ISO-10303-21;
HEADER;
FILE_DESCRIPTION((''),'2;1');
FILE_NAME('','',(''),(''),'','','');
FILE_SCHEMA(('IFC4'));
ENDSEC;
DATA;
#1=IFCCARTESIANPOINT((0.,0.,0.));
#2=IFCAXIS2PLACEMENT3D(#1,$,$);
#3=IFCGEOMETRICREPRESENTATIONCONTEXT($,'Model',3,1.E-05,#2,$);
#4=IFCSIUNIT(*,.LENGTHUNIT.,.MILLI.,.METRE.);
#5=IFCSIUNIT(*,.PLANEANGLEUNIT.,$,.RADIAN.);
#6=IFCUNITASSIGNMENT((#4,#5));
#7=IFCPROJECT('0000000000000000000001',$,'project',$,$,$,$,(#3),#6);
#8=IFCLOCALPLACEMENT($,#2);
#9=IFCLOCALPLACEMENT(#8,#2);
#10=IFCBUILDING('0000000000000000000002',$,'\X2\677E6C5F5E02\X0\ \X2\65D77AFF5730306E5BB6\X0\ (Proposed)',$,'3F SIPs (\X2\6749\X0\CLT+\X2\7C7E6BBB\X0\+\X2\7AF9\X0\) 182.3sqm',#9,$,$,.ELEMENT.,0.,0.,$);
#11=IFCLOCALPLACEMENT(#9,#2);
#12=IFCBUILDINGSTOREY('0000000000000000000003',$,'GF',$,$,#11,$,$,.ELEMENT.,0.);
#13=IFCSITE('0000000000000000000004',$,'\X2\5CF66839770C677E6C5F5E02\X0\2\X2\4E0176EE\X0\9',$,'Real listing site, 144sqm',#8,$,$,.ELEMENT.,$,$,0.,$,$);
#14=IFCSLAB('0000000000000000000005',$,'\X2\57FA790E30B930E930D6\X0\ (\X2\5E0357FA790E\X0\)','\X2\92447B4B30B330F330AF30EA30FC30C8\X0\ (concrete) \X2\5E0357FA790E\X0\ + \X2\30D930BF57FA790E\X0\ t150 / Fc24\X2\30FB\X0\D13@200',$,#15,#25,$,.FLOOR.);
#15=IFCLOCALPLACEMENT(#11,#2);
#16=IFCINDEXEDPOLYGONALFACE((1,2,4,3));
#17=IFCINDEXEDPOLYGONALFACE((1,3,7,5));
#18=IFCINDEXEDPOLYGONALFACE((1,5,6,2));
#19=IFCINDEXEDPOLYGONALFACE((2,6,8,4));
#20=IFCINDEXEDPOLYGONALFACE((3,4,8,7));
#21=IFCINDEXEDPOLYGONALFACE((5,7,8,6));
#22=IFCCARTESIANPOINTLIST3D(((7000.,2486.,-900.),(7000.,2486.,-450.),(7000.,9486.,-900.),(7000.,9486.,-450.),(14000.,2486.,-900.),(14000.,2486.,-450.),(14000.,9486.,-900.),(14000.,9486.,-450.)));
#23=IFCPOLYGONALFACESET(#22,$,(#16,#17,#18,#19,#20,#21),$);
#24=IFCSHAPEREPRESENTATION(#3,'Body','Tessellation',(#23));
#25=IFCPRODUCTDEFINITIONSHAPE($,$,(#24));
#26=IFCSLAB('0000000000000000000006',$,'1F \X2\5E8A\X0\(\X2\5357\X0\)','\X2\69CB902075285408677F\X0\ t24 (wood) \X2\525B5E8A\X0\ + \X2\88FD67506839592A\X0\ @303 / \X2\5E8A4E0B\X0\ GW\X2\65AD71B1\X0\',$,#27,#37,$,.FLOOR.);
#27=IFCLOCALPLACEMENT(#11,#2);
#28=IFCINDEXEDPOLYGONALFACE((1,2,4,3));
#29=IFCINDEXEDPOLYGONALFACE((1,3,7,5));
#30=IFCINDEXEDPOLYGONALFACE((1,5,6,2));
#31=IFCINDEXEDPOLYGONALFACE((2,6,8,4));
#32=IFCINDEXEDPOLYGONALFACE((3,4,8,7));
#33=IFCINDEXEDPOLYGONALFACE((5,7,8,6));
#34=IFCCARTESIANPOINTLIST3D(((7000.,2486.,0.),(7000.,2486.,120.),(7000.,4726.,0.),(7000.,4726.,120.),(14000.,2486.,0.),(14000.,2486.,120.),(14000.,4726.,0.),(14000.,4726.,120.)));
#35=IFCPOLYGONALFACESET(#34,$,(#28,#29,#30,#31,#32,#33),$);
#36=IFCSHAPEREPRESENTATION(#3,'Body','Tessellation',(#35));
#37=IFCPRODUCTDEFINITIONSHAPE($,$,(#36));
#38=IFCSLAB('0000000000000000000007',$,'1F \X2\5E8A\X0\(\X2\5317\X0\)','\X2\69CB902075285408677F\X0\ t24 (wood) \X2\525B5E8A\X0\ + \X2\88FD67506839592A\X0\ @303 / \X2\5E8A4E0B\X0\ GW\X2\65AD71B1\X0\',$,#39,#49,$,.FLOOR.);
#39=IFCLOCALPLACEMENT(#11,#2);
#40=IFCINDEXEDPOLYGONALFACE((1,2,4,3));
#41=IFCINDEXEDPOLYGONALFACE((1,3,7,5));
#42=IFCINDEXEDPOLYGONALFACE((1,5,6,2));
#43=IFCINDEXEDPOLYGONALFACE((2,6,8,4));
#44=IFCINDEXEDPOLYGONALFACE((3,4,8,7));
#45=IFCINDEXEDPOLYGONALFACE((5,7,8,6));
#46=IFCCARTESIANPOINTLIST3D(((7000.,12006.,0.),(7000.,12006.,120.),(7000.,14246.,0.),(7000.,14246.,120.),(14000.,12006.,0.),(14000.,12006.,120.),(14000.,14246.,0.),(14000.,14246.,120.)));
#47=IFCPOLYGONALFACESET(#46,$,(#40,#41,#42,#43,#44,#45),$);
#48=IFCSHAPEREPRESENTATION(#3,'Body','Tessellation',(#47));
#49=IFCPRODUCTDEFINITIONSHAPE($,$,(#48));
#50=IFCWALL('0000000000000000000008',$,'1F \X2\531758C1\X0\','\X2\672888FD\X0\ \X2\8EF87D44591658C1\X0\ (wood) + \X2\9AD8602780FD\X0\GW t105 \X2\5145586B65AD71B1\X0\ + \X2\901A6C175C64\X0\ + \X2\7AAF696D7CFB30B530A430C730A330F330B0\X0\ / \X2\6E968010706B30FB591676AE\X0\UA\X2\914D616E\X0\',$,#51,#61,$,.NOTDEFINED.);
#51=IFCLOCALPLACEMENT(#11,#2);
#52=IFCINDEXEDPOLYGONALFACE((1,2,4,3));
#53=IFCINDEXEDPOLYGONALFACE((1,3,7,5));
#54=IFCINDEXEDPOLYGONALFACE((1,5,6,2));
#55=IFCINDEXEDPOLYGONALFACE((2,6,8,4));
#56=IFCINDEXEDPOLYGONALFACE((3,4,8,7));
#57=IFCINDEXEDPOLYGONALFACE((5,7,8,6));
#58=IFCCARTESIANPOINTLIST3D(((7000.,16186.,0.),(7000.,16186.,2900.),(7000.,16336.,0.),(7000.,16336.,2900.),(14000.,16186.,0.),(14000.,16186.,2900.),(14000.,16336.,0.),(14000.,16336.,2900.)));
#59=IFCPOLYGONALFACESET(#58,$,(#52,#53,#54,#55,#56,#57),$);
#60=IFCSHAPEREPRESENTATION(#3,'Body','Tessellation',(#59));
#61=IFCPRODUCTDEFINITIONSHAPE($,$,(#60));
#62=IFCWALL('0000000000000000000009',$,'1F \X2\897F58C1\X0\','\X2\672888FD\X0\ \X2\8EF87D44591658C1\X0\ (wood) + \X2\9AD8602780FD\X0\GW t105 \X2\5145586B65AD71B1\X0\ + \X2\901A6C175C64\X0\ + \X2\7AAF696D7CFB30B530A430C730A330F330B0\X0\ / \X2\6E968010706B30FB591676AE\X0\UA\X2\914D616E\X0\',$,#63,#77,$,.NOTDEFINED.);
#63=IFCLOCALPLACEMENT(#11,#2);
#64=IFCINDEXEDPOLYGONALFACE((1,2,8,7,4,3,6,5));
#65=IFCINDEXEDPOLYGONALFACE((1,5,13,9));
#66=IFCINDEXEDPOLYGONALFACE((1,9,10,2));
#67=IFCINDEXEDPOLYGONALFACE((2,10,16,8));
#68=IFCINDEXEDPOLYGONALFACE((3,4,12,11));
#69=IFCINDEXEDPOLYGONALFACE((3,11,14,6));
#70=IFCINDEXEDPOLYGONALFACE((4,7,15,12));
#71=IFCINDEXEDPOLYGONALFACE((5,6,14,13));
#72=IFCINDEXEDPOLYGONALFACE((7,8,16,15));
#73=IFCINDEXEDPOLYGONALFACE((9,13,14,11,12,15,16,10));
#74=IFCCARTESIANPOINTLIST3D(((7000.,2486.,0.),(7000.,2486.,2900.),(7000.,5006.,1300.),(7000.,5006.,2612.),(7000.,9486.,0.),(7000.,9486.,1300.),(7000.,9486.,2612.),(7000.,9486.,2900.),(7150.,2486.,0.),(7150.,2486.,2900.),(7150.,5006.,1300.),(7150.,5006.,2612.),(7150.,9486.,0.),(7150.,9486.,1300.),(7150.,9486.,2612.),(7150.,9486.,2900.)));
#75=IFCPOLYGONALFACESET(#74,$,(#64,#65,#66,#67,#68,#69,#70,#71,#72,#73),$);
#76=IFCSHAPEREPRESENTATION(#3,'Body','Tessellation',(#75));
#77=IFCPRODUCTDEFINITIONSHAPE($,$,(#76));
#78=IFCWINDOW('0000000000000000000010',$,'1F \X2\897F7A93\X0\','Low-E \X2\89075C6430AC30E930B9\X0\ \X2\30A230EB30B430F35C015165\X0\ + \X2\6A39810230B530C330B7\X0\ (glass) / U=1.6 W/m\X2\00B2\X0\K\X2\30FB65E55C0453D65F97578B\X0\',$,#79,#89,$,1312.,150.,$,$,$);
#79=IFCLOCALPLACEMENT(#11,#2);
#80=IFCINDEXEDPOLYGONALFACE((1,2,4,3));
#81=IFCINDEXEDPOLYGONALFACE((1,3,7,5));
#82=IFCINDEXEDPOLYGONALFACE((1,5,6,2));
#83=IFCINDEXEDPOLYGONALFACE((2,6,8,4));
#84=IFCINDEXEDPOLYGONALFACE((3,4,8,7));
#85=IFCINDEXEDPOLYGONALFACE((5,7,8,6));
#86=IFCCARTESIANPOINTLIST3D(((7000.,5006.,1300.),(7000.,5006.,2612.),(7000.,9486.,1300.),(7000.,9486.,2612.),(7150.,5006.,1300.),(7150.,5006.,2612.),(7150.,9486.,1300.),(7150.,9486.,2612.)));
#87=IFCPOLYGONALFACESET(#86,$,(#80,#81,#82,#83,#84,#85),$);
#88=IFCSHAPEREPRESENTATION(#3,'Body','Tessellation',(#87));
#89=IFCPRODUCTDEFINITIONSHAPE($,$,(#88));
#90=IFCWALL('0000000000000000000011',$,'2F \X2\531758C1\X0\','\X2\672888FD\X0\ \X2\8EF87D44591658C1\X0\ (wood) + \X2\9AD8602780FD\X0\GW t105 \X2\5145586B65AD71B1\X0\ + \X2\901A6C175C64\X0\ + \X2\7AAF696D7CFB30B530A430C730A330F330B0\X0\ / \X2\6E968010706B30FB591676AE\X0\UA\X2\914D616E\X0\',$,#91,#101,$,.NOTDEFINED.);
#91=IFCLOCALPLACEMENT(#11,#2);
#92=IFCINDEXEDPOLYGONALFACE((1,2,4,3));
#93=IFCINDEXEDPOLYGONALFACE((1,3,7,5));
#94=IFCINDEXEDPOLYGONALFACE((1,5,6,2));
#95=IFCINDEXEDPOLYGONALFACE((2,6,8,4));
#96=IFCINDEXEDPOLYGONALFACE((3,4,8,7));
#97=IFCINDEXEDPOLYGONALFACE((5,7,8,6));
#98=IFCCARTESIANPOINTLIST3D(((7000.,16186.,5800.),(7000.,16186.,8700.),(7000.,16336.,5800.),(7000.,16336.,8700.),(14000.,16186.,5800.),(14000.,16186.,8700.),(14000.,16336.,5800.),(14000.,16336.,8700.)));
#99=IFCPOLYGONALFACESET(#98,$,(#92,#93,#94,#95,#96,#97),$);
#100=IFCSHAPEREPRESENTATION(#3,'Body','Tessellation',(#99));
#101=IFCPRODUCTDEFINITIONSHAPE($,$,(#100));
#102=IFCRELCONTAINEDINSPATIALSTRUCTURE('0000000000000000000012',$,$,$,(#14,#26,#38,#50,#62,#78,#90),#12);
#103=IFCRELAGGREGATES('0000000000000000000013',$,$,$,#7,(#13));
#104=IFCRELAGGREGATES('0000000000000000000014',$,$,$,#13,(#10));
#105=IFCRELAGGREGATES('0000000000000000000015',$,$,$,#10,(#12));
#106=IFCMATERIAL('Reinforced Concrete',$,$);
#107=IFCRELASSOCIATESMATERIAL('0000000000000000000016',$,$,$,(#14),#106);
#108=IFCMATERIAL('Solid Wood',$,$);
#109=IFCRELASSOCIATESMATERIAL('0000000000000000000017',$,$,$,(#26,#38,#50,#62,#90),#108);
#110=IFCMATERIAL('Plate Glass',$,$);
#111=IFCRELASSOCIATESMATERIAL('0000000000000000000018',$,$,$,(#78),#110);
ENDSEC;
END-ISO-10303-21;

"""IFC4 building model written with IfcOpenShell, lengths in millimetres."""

from ifc_helpers import new_model, si_unit, frame, frame_2d, origin, place, context, project, spatial, rectangle, extrude, material, element, fill, save


model = new_model("IFC4")

# Units and contexts
model_context = context("Model", 3, precision=1e-05, world=origin())
ifc_project = project(units=[si_unit("LENGTHUNIT", "METRE", prefix="MILLI"), si_unit("PLANEANGLEUNIT", "RADIAN")], contexts=[model_context])

# Site, building, storey
site_placement = place(None, origin())
site = spatial("IfcSite", under=ifc_project, at=site_placement, Name="島根県松江市2丁目9", ObjectType="Real listing site, 144sqm", CompositionType="ELEMENT", RefElevation=0.0)
building_placement = place(site_placement, origin())
building = spatial("IfcBuilding", under=site, at=building_placement, Name="松江市 旗竿地の家 (Proposed)", ObjectType="3F SIPs (杉CLT+籾殻+竹) 182.3sqm", CompositionType="ELEMENT", ElevationOfRefHeight=0.0, ElevationOfTerrain=0.0)
storey_placement = place(building_placement, origin())
storey = spatial("IfcBuildingStorey", under=building, at=storey_placement, Name="GF", CompositionType="ELEMENT", Elevation=0.0)

# Slabs
ifc_material_1 = material(Name="Reinforced Concrete")
slab_1_placement = place(storey_placement, frame((3500.0, 1243.0, -450.0)))
element("IfcSlab", 1, at=slab_1_placement, inside=storey, material=ifc_material_1, Name="基礎スラブ (布基礎)", Description="鉄筋コンクリート (concrete) 布基礎 + ベタ基礎 t150 / Fc24・D13@200", PredefinedType="FLOOR", context=model_context, shape_type="SweptSolid", body=[
    extrude(rectangle(XDim=7000.0, YDim=7000.0, at=frame_2d((3500.0, 3500.0))), frame((3500.0, 1243.0, -450.0)), (0.0, 0.0, 1.0), 450.0),
])
ifc_material_2 = material(Name="Solid Wood")
slab_2_placement = place(storey_placement, frame((3500.0, 1243.0, 0.0)))
element("IfcSlab", 2, at=slab_2_placement, inside=storey, material=ifc_material_2, Name="1F 床(南)", Description="構造用合板 t24 (wood) 剛床 + 製材根太 @303 / 床下 GW断熱", PredefinedType="FLOOR", context=model_context, shape_type="SweptSolid", body=[
    extrude(rectangle(XDim=7000.0, YDim=2240.0, at=frame_2d((3500.0, 1120.0))), frame((3500.0, 1243.0, 0.0)), (0.0, 0.0, 1.0), 120.0),
])
slab_3_placement = place(storey_placement, frame((3500.0, 6003.0, 0.0)))
element("IfcSlab", 3, at=slab_3_placement, inside=storey, material=ifc_material_2, Name="1F 床(北)", Description="構造用合板 t24 (wood) 剛床 + 製材根太 @303 / 床下 GW断熱", PredefinedType="FLOOR", context=model_context, shape_type="SweptSolid", body=[
    extrude(rectangle(XDim=7000.0, YDim=2240.0, at=frame_2d((3500.0, 1120.0))), frame((3500.0, 6003.0, 0.0)), (0.0, 0.0, 1.0), 120.0),
])

# Shared definitions
ifc_material_3 = material(Name="Plate Glass")

# Wall
wall_1_placement = place(storey_placement, frame((3500.0, 8093.0, 0.0)))
element("IfcWall", 4, at=wall_1_placement, inside=storey, material=ifc_material_2, Name="1F 北壁", Description="木製 軸組外壁 (wood) + 高性能GW t105 充填断熱 + 通気層 + 窯業系サイディング / 準耐火・外皮UA配慮", PredefinedType="NOTDEFINED", context=model_context, shape_type="SweptSolid", body=[
    extrude(rectangle(XDim=7000.0, YDim=150.0, at=frame_2d((3500.0, 75.0))), frame((3500.0, 8093.0, 0.0)), (0.0, 0.0, 1.0), 2900.0),
])

# Wall, opening, window
wall_2_placement = place(storey_placement, frame((3500.0, 1243.0, 0.0)))
wall_2 = element("IfcWall", 5, at=wall_2_placement, inside=storey, material=ifc_material_2, Name="1F 西壁", Description="木製 軸組外壁 (wood) + 高性能GW t105 充填断熱 + 通気層 + 窯業系サイディング / 準耐火・外皮UA配慮", PredefinedType="NOTDEFINED", context=model_context, shape_type="SweptSolid", body=[
    extrude(rectangle(XDim=150.0, YDim=7000.0, at=frame_2d((75.0, 3500.0))), frame((3500.0, 1243.0, 0.0)), (0.0, 0.0, 1.0), 2900.0),
])
opening_1_placement = place(storey_placement, frame((3500.0, 2503.0, 650.0)))
opening_1 = element("IfcOpeningElement", 6, at=opening_1_placement, cuts=wall_2, PredefinedType="NOTDEFINED", context=model_context, shape_type="SweptSolid", body=[
    extrude(rectangle(XDim=150.0, YDim=4480.0, at=frame_2d((75.0, 2240.0))), frame((3500.0, 2503.0, 650.0)), (0.0, 0.0, 1.0), 1312.0),
])
window_1_placement = place(storey_placement, frame((3500.0, 2503.0, 650.0)))
window_1 = element("IfcWindow", 7, at=window_1_placement, inside=storey, material=ifc_material_3, Name="1F 西窓", Description="Low-E 複層ガラス アルゴン封入 + 樹脂サッシ (glass) / U=1.6 W/m²K・日射取得型", OverallHeight=1312.0, OverallWidth=150.0, context=model_context, shape_type="SweptSolid", body=[
    extrude(rectangle(XDim=150.0, YDim=4480.0, at=frame_2d((75.0, 2240.0))), frame((3500.0, 2503.0, 650.0)), (0.0, 0.0, 1.0), 1312.0),
])
fill(opening_1, window_1)

# Wall
wall_3_placement = place(storey_placement, frame((3500.0, 8093.0, 2900.0)))
element("IfcWall", 8, at=wall_3_placement, inside=storey, material=ifc_material_2, Name="2F 北壁", Description="木製 軸組外壁 (wood) + 高性能GW t105 充填断熱 + 通気層 + 窯業系サイディング / 準耐火・外皮UA配慮", PredefinedType="NOTDEFINED", context=model_context, shape_type="SweptSolid", body=[
    extrude(rectangle(XDim=7000.0, YDim=150.0, at=frame_2d((3500.0, 75.0))), frame((3500.0, 8093.0, 2900.0)), (0.0, 0.0, 1.0), 2900.0),
])

save(model, "model.ifc")
